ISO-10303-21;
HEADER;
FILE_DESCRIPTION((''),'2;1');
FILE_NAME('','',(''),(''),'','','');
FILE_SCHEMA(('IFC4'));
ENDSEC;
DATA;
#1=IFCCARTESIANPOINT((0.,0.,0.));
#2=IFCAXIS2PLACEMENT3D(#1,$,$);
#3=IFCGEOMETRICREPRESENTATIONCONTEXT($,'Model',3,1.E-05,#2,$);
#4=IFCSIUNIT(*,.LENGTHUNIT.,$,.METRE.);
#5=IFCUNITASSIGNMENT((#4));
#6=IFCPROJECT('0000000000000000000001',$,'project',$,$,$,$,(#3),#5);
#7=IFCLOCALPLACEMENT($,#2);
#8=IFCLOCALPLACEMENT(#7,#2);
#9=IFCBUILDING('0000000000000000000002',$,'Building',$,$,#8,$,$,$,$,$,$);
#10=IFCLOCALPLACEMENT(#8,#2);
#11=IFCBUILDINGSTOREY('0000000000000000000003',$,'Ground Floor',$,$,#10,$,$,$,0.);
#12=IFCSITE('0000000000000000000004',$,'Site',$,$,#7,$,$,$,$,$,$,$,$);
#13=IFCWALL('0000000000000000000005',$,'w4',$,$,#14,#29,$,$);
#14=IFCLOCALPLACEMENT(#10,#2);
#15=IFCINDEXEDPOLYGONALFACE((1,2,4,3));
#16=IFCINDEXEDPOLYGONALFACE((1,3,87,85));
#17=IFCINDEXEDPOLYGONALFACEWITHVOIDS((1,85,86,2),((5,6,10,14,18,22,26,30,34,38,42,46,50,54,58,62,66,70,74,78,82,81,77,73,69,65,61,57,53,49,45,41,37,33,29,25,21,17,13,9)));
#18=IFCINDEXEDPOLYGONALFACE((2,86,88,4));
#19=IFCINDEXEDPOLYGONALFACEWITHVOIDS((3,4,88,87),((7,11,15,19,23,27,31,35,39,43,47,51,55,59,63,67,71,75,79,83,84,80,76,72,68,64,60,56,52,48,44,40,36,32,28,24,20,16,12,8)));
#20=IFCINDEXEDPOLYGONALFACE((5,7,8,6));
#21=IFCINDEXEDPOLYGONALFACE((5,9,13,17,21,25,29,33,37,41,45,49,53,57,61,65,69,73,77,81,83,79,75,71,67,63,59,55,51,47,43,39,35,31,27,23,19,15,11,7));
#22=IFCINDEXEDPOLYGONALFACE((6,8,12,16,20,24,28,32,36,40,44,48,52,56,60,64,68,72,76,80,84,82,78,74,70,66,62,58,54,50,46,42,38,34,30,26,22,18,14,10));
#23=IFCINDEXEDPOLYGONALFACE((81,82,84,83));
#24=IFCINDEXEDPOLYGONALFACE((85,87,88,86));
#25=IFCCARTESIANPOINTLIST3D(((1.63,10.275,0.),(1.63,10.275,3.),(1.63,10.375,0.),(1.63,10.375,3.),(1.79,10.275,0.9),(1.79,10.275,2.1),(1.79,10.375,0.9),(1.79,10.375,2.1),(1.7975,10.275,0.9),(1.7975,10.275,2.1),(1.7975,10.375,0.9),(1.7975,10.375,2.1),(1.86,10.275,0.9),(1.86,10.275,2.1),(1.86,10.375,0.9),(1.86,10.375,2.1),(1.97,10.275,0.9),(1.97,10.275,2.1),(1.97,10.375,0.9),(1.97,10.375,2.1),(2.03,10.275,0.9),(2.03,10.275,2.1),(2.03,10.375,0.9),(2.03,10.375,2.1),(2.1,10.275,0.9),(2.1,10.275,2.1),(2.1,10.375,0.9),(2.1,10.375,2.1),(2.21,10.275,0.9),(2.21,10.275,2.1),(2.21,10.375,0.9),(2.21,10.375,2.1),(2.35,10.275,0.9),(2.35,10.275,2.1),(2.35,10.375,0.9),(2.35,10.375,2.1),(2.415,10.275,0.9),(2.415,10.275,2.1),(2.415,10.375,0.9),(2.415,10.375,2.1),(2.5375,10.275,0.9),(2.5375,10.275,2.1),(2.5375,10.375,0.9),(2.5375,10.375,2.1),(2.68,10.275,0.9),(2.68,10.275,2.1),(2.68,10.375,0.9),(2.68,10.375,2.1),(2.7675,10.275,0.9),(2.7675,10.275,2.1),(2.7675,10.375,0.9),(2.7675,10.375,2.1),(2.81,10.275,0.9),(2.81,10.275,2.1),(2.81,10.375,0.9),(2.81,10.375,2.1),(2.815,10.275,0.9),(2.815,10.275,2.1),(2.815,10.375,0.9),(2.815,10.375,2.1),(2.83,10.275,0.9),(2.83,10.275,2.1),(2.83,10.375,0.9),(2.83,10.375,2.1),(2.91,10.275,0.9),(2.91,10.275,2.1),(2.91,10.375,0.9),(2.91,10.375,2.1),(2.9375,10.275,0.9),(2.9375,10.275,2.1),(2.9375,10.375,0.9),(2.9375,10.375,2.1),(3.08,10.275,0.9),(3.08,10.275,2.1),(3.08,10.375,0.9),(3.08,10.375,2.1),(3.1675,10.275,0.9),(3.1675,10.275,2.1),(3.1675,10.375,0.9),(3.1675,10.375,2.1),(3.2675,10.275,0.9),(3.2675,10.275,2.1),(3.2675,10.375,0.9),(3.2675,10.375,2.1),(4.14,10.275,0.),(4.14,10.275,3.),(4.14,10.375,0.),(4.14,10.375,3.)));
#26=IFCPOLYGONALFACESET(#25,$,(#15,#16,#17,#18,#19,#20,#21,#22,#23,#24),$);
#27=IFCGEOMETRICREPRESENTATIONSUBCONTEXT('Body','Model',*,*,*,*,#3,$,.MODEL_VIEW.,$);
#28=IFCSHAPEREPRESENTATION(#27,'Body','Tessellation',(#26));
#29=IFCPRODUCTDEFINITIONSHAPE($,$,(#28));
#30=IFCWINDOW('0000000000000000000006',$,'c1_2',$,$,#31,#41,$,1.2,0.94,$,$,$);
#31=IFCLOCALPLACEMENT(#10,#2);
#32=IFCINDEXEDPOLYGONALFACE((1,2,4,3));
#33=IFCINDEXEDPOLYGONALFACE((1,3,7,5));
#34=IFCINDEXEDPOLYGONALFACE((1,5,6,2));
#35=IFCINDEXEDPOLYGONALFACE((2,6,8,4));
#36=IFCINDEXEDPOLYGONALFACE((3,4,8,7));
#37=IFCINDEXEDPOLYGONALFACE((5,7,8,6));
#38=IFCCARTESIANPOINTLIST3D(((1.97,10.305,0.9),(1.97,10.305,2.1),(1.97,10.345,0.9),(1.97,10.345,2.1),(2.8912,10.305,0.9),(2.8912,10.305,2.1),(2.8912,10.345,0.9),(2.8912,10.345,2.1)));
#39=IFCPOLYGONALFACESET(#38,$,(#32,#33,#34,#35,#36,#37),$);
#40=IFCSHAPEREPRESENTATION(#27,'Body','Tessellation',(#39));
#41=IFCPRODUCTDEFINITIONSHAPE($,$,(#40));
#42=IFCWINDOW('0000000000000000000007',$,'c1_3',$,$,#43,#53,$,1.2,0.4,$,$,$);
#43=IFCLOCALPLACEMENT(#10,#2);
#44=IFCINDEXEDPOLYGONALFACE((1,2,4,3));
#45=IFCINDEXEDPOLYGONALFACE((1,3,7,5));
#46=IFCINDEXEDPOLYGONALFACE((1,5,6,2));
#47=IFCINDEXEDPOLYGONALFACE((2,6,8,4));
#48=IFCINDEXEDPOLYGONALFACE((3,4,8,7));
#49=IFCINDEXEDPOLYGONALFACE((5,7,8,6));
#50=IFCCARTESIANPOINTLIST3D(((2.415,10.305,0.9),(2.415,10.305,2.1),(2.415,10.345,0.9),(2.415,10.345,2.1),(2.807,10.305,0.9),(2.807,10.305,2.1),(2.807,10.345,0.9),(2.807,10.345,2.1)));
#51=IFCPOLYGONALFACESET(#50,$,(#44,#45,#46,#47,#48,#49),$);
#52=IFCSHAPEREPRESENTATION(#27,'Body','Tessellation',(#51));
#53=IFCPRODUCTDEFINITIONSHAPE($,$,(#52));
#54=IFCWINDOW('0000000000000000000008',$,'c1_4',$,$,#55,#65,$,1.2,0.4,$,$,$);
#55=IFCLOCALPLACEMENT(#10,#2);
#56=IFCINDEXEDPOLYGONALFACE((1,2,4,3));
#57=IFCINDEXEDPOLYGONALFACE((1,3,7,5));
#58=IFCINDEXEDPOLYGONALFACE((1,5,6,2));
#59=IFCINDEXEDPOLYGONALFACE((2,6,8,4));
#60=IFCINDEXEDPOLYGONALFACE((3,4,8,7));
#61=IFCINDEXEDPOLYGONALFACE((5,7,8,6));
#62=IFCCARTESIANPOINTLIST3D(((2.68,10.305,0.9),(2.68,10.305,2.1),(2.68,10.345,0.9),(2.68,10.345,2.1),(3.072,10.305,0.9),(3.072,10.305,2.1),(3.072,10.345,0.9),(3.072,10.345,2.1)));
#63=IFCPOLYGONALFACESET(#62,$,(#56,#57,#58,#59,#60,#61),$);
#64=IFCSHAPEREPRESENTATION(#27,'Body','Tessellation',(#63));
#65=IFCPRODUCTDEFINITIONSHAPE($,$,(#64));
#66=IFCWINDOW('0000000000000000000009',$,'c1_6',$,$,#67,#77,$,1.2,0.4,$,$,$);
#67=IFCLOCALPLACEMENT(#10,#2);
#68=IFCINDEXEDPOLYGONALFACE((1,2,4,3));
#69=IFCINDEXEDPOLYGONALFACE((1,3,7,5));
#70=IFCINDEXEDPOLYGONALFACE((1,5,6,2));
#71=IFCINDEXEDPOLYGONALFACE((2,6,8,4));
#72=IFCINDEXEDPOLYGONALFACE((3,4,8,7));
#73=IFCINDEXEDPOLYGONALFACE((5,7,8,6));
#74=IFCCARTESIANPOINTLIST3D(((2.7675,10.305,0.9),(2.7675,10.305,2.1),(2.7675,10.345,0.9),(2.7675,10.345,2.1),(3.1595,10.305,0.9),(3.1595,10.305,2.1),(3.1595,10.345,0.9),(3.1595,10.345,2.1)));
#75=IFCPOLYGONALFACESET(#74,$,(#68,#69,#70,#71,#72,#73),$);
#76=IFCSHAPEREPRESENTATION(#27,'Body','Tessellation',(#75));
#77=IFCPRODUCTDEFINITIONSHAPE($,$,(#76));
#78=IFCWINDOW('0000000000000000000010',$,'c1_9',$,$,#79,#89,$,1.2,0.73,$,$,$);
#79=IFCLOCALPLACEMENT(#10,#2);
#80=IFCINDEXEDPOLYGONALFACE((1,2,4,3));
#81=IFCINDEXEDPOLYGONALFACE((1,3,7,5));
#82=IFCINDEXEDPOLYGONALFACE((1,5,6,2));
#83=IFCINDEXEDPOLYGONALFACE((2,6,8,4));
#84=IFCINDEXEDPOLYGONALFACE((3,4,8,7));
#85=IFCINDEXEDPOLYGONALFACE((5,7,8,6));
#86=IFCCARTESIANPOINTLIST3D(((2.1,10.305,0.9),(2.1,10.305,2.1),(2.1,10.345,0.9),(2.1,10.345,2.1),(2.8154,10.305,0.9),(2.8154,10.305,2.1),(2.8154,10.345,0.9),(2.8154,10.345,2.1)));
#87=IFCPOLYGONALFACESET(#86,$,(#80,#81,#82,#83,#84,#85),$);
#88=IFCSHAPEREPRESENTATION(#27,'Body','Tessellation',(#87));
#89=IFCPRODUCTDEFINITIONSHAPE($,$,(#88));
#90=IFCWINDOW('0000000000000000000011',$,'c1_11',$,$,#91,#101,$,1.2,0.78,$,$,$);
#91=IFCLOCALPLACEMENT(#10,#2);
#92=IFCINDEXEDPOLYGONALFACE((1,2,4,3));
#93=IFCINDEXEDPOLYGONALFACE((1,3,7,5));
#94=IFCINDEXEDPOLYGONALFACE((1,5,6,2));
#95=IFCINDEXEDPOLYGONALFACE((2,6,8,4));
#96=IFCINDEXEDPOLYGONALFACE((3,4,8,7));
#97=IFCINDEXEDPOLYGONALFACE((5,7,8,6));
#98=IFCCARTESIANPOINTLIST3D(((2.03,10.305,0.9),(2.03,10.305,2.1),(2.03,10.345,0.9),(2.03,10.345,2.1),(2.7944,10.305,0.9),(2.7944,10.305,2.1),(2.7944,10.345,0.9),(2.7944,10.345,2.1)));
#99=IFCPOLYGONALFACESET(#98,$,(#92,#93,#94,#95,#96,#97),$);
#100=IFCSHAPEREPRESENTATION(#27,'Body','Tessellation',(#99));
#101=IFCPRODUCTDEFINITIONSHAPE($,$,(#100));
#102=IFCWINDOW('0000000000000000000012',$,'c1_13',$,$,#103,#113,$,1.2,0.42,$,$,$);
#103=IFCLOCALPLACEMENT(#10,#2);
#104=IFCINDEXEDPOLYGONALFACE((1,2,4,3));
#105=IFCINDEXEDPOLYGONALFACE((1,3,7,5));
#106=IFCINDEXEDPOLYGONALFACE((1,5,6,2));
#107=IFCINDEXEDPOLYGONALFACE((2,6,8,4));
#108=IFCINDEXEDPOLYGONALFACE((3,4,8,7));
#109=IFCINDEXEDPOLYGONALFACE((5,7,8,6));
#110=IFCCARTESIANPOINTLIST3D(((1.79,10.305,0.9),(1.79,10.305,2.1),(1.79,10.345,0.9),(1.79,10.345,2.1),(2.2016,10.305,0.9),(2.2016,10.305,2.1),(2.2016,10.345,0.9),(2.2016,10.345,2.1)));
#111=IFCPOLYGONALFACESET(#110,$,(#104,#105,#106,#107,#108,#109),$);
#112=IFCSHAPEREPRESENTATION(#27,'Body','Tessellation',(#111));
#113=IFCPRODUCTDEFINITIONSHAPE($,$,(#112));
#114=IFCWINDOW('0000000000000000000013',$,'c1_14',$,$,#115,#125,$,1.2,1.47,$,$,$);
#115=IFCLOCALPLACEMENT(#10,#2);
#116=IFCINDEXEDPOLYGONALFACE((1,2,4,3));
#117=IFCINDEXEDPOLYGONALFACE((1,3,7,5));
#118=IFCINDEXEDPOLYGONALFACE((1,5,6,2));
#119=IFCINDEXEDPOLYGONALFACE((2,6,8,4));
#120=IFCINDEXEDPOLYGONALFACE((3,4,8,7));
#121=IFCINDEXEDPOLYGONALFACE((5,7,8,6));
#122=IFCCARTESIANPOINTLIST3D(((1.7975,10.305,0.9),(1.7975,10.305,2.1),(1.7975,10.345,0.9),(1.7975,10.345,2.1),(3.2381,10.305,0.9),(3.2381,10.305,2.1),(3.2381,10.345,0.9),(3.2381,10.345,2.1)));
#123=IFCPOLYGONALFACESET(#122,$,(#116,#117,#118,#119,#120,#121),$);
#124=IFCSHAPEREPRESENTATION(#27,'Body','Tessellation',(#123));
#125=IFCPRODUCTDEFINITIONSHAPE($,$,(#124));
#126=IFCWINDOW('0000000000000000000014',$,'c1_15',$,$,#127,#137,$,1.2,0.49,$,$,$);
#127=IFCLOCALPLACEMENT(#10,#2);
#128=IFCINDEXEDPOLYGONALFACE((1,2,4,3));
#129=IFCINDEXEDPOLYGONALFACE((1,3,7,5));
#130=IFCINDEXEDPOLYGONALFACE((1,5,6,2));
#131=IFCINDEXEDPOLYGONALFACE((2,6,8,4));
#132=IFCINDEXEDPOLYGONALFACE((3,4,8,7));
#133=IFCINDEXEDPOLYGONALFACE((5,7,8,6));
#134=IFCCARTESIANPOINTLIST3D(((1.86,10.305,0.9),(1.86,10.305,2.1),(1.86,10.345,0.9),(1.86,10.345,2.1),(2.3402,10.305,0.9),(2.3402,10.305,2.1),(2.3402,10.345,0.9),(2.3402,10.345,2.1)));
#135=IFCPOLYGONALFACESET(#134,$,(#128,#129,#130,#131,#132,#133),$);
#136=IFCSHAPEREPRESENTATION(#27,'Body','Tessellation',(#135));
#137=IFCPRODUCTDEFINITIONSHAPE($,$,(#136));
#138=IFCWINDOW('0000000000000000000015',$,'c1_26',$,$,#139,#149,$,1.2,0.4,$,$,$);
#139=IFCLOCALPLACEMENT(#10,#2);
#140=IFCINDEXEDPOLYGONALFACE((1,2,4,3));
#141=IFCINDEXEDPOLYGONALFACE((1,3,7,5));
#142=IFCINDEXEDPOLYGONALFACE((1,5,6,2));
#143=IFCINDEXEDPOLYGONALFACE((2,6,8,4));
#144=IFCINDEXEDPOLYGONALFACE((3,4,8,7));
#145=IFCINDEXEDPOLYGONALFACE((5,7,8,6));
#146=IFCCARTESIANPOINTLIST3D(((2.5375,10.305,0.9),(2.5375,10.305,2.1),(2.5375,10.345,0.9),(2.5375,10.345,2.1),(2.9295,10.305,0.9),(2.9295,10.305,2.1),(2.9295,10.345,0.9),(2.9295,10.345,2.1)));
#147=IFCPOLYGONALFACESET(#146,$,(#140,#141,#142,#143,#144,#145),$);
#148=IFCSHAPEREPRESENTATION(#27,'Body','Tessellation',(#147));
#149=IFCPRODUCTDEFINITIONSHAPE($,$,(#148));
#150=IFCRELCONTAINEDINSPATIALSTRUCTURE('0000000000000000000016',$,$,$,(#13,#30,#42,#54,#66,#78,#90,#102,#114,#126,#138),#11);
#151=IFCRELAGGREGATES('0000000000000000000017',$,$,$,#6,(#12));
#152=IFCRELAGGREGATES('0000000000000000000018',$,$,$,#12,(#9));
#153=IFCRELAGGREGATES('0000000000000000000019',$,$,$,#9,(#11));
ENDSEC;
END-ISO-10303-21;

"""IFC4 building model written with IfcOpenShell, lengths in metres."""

from ifc_helpers import new_model, si_unit, frame, origin, place, context, subcontext, project, spatial, polyline, outline, extrude, element, fill, save


model = new_model("IFC4")

# Units and contexts
model_context = context("Model", 3, precision=1e-05, world=origin())
body_context = subcontext(model_context, "Body", "Model", "MODEL_VIEW")
ifc_project = project(units=[si_unit("LENGTHUNIT", "METRE")], contexts=[model_context])

# Site, building, storey
site_placement = place(None, origin())
site = spatial("IfcSite", under=ifc_project, at=site_placement, Name="Site")
building_placement = place(site_placement, origin())
building = spatial("IfcBuilding", under=site, at=building_placement, Name="Building")
storey_placement = place(building_placement, origin())
storey = spatial("IfcBuildingStorey", under=building, at=storey_placement, Name="Ground Floor", Elevation=0.0)

# Wall, openings, windows
wall_1_placement = place(storey_placement, frame((1.63, 10.325, 0.0), x_axis=(1.0, 0.0, 0.0)))
wall_1 = element("IfcWall", 1, at=wall_1_placement, inside=storey, Name="w4", context=body_context, shape_type="SweptSolid", body=[
    extrude(outline(polyline([(0.0, -0.05), (2.51, -0.05), (2.51, 0.05), (0.0, 0.05), (0.0, -0.05)])), origin(), (0.0, 0.0, 1.0), 3.0),
])
opening_1_placement = place(wall_1_placement, frame((0.34, 0.0, 0.0)))
opening_1 = element("IfcOpeningElement", 2, at=opening_1_placement, cuts=wall_1, context=body_context, shape_type="SweptSolid", body=[
    extrude(outline(polyline([(0.0, -0.0525), (0.94, -0.0525), (0.94, 0.0525), (0.0, 0.0525), (0.0, -0.0525)])), frame((0.0, 0.0, 0.9)), (0.0, 0.0, 1.0), 1.2),
])
opening_2_placement = place(wall_1_placement, frame((0.785, 0.0, 0.0)))
opening_2 = element("IfcOpeningElement", 3, at=opening_2_placement, cuts=wall_1, context=body_context, shape_type="SweptSolid", body=[
    extrude(outline(polyline([(0.0, -0.0525), (0.4, -0.0525), (0.4, 0.0525), (0.0, 0.0525), (0.0, -0.0525)])), frame((0.0, 0.0, 0.9)), (0.0, 0.0, 1.0), 1.2),
])
opening_3_placement = place(wall_1_placement, frame((1.05, 0.0, 0.0)))
opening_3 = element("IfcOpeningElement", 4, at=opening_3_placement, cuts=wall_1, context=body_context, shape_type="SweptSolid", body=[
    extrude(outline(polyline([(0.0, -0.0525), (0.4, -0.0525), (0.4, 0.0525), (0.0, 0.0525), (0.0, -0.0525)])), frame((0.0, 0.0, 0.9)), (0.0, 0.0, 1.0), 1.2),
])
opening_4_placement = place(wall_1_placement, frame((1.1375, 0.0, 0.0)))
opening_4 = element("IfcOpeningElement", 5, at=opening_4_placement, cuts=wall_1, context=body_context, shape_type="SweptSolid", body=[
    extrude(outline(polyline([(0.0, -0.0525), (0.4, -0.0525), (0.4, 0.0525), (0.0, 0.0525), (0.0, -0.0525)])), frame((0.0, 0.0, 0.9)), (0.0, 0.0, 1.0), 1.2),
])
opening_5_placement = place(wall_1_placement, frame((0.47, 0.0, 0.0)))
opening_5 = element("IfcOpeningElement", 6, at=opening_5_placement, cuts=wall_1, context=body_context, shape_type="SweptSolid", body=[
    extrude(outline(polyline([(0.0, -0.0525), (0.73, -0.0525), (0.73, 0.0525), (0.0, 0.0525), (0.0, -0.0525)])), frame((0.0, 0.0, 0.9)), (0.0, 0.0, 1.0), 1.2),
])
opening_6_placement = place(wall_1_placement, frame((0.4, 0.0, 0.0)))
opening_6 = element("IfcOpeningElement", 7, at=opening_6_placement, cuts=wall_1, context=body_context, shape_type="SweptSolid", body=[
    extrude(outline(polyline([(0.0, -0.0525), (0.78, -0.0525), (0.78, 0.0525), (0.0, 0.0525), (0.0, -0.0525)])), frame((0.0, 0.0, 0.9)), (0.0, 0.0, 1.0), 1.2),
])
opening_7_placement = place(wall_1_placement, frame((0.16, 0.0, 0.0)))
opening_7 = element("IfcOpeningElement", 8, at=opening_7_placement, cuts=wall_1, context=body_context, shape_type="SweptSolid", body=[
    extrude(outline(polyline([(0.0, -0.0525), (0.42, -0.0525), (0.42, 0.0525), (0.0, 0.0525), (0.0, -0.0525)])), frame((0.0, 0.0, 0.9)), (0.0, 0.0, 1.0), 1.2),
])
opening_8_placement = place(wall_1_placement, frame((0.1675, 0.0, 0.0)))
opening_8 = element("IfcOpeningElement", 9, at=opening_8_placement, cuts=wall_1, context=body_context, shape_type="SweptSolid", body=[
    extrude(outline(polyline([(0.0, -0.0525), (1.47, -0.0525), (1.47, 0.0525), (0.0, 0.0525), (0.0, -0.0525)])), frame((0.0, 0.0, 0.9)), (0.0, 0.0, 1.0), 1.2),
])
opening_9_placement = place(wall_1_placement, frame((0.23, 0.0, 0.0)))
opening_9 = element("IfcOpeningElement", 10, at=opening_9_placement, cuts=wall_1, context=body_context, shape_type="SweptSolid", body=[
    extrude(outline(polyline([(0.0, -0.0525), (0.49, -0.0525), (0.49, 0.0525), (0.0, 0.0525), (0.0, -0.0525)])), frame((0.0, 0.0, 0.9)), (0.0, 0.0, 1.0), 1.2),
])
opening_10_placement = place(wall_1_placement, frame((0.9075, 0.0, 0.0)))
opening_10 = element("IfcOpeningElement", 11, at=opening_10_placement, cuts=wall_1, context=body_context, shape_type="SweptSolid", body=[
    extrude(outline(polyline([(0.0, -0.0525), (0.4, -0.0525), (0.4, 0.0525), (0.0, 0.0525), (0.0, -0.0525)])), frame((0.0, 0.0, 0.9)), (0.0, 0.0, 1.0), 1.2),
])
window_1_placement = place(wall_1_placement, frame((0.34, 0.0, 0.0)))
window_1 = element("IfcWindow", 12, at=window_1_placement, inside=storey, Name="c1_2", OverallHeight=1.2, OverallWidth=0.94, context=body_context, shape_type="SweptSolid", body=[
    extrude(outline(polyline([(0.0, -0.02), (0.9212, -0.02), (0.9212, 0.02), (0.0, 0.02), (0.0, -0.02)])), frame((0.0, 0.0, 0.9)), (0.0, 0.0, 1.0), 1.2),
])
fill(opening_1, window_1)
window_2_placement = place(wall_1_placement, frame((0.785, 0.0, 0.0)))
window_2 = element("IfcWindow", 13, at=window_2_placement, inside=storey, Name="c1_3", OverallHeight=1.2, OverallWidth=0.4, context=body_context, shape_type="SweptSolid", body=[
    extrude(outline(polyline([(0.0, -0.02), (0.392, -0.02), (0.392, 0.02), (0.0, 0.02), (0.0, -0.02)])), frame((0.0, 0.0, 0.9)), (0.0, 0.0, 1.0), 1.2),
])
fill(opening_2, window_2)
window_3_placement = place(wall_1_placement, frame((1.05, 0.0, 0.0)))
window_3 = element("IfcWindow", 14, at=window_3_placement, inside=storey, Name="c1_4", OverallHeight=1.2, OverallWidth=0.4, context=body_context, shape_type="SweptSolid", body=[
    extrude(outline(polyline([(0.0, -0.02), (0.392, -0.02), (0.392, 0.02), (0.0, 0.02), (0.0, -0.02)])), frame((0.0, 0.0, 0.9)), (0.0, 0.0, 1.0), 1.2),
])
fill(opening_3, window_3)
window_4_placement = place(wall_1_placement, frame((1.1375, 0.0, 0.0)))
window_4 = element("IfcWindow", 15, at=window_4_placement, inside=storey, Name="c1_6", OverallHeight=1.2, OverallWidth=0.4, context=body_context, shape_type="SweptSolid", body=[
    extrude(outline(polyline([(0.0, -0.02), (0.392, -0.02), (0.392, 0.02), (0.0, 0.02), (0.0, -0.02)])), frame((0.0, 0.0, 0.9)), (0.0, 0.0, 1.0), 1.2),
])
fill(opening_4, window_4)
window_5_placement = place(wall_1_placement, frame((0.47, 0.0, 0.0)))
window_5 = element("IfcWindow", 16, at=window_5_placement, inside=storey, Name="c1_9", OverallHeight=1.2, OverallWidth=0.73, context=body_context, shape_type="SweptSolid", body=[
    extrude(outline(polyline([(0.0, -0.02), (0.7154, -0.02), (0.7154, 0.02), (0.0, 0.02), (0.0, -0.02)])), frame((0.0, 0.0, 0.9)), (0.0, 0.0, 1.0), 1.2),
])
fill(opening_5, window_5)
window_6_placement = place(wall_1_placement, frame((0.4, 0.0, 0.0)))
window_6 = element("IfcWindow", 17, at=window_6_placement, inside=storey, Name="c1_11", OverallHeight=1.2, OverallWidth=0.78, context=body_context, shape_type="SweptSolid", body=[
    extrude(outline(polyline([(0.0, -0.02), (0.7644, -0.02), (0.7644, 0.02), (0.0, 0.02), (0.0, -0.02)])), frame((0.0, 0.0, 0.9)), (0.0, 0.0, 1.0), 1.2),
])
fill(opening_6, window_6)
window_7_placement = place(wall_1_placement, frame((0.16, 0.0, 0.0)))
window_7 = element("IfcWindow", 18, at=window_7_placement, inside=storey, Name="c1_13", OverallHeight=1.2, OverallWidth=0.42, context=body_context, shape_type="SweptSolid", body=[
    extrude(outline(polyline([(0.0, -0.02), (0.4116, -0.02), (0.4116, 0.02), (0.0, 0.02), (0.0, -0.02)])), frame((0.0, 0.0, 0.9)), (0.0, 0.0, 1.0), 1.2),
])
fill(opening_7, window_7)
window_8_placement = place(wall_1_placement, frame((0.1675, 0.0, 0.0)))
window_8 = element("IfcWindow", 19, at=window_8_placement, inside=storey, Name="c1_14", OverallHeight=1.2, OverallWidth=1.47, context=body_context, shape_type="SweptSolid", body=[
    extrude(outline(polyline([(0.0, -0.02), (1.4406, -0.02), (1.4406, 0.02), (0.0, 0.02), (0.0, -0.02)])), frame((0.0, 0.0, 0.9)), (0.0, 0.0, 1.0), 1.2),
])
fill(opening_8, window_8)
window_9_placement = place(wall_1_placement, frame((0.23, 0.0, 0.0)))
window_9 = element("IfcWindow", 20, at=window_9_placement, inside=storey, Name="c1_15", OverallHeight=1.2, OverallWidth=0.49, context=body_context, shape_type="SweptSolid", body=[
    extrude(outline(polyline([(0.0, -0.02), (0.4802, -0.02), (0.4802, 0.02), (0.0, 0.02), (0.0, -0.02)])), frame((0.0, 0.0, 0.9)), (0.0, 0.0, 1.0), 1.2),
])
fill(opening_9, window_9)
window_10_placement = place(wall_1_placement, frame((0.9075, 0.0, 0.0)))
window_10 = element("IfcWindow", 21, at=window_10_placement, inside=storey, Name="c1_26", OverallHeight=1.2, OverallWidth=0.4, context=body_context, shape_type="SweptSolid", body=[
    extrude(outline(polyline([(0.0, -0.02), (0.392, -0.02), (0.392, 0.02), (0.0, 0.02), (0.0, -0.02)])), frame((0.0, 0.0, 0.9)), (0.0, 0.0, 1.0), 1.2),
])
fill(opening_10, window_10)

save(model, "model.ifc")
